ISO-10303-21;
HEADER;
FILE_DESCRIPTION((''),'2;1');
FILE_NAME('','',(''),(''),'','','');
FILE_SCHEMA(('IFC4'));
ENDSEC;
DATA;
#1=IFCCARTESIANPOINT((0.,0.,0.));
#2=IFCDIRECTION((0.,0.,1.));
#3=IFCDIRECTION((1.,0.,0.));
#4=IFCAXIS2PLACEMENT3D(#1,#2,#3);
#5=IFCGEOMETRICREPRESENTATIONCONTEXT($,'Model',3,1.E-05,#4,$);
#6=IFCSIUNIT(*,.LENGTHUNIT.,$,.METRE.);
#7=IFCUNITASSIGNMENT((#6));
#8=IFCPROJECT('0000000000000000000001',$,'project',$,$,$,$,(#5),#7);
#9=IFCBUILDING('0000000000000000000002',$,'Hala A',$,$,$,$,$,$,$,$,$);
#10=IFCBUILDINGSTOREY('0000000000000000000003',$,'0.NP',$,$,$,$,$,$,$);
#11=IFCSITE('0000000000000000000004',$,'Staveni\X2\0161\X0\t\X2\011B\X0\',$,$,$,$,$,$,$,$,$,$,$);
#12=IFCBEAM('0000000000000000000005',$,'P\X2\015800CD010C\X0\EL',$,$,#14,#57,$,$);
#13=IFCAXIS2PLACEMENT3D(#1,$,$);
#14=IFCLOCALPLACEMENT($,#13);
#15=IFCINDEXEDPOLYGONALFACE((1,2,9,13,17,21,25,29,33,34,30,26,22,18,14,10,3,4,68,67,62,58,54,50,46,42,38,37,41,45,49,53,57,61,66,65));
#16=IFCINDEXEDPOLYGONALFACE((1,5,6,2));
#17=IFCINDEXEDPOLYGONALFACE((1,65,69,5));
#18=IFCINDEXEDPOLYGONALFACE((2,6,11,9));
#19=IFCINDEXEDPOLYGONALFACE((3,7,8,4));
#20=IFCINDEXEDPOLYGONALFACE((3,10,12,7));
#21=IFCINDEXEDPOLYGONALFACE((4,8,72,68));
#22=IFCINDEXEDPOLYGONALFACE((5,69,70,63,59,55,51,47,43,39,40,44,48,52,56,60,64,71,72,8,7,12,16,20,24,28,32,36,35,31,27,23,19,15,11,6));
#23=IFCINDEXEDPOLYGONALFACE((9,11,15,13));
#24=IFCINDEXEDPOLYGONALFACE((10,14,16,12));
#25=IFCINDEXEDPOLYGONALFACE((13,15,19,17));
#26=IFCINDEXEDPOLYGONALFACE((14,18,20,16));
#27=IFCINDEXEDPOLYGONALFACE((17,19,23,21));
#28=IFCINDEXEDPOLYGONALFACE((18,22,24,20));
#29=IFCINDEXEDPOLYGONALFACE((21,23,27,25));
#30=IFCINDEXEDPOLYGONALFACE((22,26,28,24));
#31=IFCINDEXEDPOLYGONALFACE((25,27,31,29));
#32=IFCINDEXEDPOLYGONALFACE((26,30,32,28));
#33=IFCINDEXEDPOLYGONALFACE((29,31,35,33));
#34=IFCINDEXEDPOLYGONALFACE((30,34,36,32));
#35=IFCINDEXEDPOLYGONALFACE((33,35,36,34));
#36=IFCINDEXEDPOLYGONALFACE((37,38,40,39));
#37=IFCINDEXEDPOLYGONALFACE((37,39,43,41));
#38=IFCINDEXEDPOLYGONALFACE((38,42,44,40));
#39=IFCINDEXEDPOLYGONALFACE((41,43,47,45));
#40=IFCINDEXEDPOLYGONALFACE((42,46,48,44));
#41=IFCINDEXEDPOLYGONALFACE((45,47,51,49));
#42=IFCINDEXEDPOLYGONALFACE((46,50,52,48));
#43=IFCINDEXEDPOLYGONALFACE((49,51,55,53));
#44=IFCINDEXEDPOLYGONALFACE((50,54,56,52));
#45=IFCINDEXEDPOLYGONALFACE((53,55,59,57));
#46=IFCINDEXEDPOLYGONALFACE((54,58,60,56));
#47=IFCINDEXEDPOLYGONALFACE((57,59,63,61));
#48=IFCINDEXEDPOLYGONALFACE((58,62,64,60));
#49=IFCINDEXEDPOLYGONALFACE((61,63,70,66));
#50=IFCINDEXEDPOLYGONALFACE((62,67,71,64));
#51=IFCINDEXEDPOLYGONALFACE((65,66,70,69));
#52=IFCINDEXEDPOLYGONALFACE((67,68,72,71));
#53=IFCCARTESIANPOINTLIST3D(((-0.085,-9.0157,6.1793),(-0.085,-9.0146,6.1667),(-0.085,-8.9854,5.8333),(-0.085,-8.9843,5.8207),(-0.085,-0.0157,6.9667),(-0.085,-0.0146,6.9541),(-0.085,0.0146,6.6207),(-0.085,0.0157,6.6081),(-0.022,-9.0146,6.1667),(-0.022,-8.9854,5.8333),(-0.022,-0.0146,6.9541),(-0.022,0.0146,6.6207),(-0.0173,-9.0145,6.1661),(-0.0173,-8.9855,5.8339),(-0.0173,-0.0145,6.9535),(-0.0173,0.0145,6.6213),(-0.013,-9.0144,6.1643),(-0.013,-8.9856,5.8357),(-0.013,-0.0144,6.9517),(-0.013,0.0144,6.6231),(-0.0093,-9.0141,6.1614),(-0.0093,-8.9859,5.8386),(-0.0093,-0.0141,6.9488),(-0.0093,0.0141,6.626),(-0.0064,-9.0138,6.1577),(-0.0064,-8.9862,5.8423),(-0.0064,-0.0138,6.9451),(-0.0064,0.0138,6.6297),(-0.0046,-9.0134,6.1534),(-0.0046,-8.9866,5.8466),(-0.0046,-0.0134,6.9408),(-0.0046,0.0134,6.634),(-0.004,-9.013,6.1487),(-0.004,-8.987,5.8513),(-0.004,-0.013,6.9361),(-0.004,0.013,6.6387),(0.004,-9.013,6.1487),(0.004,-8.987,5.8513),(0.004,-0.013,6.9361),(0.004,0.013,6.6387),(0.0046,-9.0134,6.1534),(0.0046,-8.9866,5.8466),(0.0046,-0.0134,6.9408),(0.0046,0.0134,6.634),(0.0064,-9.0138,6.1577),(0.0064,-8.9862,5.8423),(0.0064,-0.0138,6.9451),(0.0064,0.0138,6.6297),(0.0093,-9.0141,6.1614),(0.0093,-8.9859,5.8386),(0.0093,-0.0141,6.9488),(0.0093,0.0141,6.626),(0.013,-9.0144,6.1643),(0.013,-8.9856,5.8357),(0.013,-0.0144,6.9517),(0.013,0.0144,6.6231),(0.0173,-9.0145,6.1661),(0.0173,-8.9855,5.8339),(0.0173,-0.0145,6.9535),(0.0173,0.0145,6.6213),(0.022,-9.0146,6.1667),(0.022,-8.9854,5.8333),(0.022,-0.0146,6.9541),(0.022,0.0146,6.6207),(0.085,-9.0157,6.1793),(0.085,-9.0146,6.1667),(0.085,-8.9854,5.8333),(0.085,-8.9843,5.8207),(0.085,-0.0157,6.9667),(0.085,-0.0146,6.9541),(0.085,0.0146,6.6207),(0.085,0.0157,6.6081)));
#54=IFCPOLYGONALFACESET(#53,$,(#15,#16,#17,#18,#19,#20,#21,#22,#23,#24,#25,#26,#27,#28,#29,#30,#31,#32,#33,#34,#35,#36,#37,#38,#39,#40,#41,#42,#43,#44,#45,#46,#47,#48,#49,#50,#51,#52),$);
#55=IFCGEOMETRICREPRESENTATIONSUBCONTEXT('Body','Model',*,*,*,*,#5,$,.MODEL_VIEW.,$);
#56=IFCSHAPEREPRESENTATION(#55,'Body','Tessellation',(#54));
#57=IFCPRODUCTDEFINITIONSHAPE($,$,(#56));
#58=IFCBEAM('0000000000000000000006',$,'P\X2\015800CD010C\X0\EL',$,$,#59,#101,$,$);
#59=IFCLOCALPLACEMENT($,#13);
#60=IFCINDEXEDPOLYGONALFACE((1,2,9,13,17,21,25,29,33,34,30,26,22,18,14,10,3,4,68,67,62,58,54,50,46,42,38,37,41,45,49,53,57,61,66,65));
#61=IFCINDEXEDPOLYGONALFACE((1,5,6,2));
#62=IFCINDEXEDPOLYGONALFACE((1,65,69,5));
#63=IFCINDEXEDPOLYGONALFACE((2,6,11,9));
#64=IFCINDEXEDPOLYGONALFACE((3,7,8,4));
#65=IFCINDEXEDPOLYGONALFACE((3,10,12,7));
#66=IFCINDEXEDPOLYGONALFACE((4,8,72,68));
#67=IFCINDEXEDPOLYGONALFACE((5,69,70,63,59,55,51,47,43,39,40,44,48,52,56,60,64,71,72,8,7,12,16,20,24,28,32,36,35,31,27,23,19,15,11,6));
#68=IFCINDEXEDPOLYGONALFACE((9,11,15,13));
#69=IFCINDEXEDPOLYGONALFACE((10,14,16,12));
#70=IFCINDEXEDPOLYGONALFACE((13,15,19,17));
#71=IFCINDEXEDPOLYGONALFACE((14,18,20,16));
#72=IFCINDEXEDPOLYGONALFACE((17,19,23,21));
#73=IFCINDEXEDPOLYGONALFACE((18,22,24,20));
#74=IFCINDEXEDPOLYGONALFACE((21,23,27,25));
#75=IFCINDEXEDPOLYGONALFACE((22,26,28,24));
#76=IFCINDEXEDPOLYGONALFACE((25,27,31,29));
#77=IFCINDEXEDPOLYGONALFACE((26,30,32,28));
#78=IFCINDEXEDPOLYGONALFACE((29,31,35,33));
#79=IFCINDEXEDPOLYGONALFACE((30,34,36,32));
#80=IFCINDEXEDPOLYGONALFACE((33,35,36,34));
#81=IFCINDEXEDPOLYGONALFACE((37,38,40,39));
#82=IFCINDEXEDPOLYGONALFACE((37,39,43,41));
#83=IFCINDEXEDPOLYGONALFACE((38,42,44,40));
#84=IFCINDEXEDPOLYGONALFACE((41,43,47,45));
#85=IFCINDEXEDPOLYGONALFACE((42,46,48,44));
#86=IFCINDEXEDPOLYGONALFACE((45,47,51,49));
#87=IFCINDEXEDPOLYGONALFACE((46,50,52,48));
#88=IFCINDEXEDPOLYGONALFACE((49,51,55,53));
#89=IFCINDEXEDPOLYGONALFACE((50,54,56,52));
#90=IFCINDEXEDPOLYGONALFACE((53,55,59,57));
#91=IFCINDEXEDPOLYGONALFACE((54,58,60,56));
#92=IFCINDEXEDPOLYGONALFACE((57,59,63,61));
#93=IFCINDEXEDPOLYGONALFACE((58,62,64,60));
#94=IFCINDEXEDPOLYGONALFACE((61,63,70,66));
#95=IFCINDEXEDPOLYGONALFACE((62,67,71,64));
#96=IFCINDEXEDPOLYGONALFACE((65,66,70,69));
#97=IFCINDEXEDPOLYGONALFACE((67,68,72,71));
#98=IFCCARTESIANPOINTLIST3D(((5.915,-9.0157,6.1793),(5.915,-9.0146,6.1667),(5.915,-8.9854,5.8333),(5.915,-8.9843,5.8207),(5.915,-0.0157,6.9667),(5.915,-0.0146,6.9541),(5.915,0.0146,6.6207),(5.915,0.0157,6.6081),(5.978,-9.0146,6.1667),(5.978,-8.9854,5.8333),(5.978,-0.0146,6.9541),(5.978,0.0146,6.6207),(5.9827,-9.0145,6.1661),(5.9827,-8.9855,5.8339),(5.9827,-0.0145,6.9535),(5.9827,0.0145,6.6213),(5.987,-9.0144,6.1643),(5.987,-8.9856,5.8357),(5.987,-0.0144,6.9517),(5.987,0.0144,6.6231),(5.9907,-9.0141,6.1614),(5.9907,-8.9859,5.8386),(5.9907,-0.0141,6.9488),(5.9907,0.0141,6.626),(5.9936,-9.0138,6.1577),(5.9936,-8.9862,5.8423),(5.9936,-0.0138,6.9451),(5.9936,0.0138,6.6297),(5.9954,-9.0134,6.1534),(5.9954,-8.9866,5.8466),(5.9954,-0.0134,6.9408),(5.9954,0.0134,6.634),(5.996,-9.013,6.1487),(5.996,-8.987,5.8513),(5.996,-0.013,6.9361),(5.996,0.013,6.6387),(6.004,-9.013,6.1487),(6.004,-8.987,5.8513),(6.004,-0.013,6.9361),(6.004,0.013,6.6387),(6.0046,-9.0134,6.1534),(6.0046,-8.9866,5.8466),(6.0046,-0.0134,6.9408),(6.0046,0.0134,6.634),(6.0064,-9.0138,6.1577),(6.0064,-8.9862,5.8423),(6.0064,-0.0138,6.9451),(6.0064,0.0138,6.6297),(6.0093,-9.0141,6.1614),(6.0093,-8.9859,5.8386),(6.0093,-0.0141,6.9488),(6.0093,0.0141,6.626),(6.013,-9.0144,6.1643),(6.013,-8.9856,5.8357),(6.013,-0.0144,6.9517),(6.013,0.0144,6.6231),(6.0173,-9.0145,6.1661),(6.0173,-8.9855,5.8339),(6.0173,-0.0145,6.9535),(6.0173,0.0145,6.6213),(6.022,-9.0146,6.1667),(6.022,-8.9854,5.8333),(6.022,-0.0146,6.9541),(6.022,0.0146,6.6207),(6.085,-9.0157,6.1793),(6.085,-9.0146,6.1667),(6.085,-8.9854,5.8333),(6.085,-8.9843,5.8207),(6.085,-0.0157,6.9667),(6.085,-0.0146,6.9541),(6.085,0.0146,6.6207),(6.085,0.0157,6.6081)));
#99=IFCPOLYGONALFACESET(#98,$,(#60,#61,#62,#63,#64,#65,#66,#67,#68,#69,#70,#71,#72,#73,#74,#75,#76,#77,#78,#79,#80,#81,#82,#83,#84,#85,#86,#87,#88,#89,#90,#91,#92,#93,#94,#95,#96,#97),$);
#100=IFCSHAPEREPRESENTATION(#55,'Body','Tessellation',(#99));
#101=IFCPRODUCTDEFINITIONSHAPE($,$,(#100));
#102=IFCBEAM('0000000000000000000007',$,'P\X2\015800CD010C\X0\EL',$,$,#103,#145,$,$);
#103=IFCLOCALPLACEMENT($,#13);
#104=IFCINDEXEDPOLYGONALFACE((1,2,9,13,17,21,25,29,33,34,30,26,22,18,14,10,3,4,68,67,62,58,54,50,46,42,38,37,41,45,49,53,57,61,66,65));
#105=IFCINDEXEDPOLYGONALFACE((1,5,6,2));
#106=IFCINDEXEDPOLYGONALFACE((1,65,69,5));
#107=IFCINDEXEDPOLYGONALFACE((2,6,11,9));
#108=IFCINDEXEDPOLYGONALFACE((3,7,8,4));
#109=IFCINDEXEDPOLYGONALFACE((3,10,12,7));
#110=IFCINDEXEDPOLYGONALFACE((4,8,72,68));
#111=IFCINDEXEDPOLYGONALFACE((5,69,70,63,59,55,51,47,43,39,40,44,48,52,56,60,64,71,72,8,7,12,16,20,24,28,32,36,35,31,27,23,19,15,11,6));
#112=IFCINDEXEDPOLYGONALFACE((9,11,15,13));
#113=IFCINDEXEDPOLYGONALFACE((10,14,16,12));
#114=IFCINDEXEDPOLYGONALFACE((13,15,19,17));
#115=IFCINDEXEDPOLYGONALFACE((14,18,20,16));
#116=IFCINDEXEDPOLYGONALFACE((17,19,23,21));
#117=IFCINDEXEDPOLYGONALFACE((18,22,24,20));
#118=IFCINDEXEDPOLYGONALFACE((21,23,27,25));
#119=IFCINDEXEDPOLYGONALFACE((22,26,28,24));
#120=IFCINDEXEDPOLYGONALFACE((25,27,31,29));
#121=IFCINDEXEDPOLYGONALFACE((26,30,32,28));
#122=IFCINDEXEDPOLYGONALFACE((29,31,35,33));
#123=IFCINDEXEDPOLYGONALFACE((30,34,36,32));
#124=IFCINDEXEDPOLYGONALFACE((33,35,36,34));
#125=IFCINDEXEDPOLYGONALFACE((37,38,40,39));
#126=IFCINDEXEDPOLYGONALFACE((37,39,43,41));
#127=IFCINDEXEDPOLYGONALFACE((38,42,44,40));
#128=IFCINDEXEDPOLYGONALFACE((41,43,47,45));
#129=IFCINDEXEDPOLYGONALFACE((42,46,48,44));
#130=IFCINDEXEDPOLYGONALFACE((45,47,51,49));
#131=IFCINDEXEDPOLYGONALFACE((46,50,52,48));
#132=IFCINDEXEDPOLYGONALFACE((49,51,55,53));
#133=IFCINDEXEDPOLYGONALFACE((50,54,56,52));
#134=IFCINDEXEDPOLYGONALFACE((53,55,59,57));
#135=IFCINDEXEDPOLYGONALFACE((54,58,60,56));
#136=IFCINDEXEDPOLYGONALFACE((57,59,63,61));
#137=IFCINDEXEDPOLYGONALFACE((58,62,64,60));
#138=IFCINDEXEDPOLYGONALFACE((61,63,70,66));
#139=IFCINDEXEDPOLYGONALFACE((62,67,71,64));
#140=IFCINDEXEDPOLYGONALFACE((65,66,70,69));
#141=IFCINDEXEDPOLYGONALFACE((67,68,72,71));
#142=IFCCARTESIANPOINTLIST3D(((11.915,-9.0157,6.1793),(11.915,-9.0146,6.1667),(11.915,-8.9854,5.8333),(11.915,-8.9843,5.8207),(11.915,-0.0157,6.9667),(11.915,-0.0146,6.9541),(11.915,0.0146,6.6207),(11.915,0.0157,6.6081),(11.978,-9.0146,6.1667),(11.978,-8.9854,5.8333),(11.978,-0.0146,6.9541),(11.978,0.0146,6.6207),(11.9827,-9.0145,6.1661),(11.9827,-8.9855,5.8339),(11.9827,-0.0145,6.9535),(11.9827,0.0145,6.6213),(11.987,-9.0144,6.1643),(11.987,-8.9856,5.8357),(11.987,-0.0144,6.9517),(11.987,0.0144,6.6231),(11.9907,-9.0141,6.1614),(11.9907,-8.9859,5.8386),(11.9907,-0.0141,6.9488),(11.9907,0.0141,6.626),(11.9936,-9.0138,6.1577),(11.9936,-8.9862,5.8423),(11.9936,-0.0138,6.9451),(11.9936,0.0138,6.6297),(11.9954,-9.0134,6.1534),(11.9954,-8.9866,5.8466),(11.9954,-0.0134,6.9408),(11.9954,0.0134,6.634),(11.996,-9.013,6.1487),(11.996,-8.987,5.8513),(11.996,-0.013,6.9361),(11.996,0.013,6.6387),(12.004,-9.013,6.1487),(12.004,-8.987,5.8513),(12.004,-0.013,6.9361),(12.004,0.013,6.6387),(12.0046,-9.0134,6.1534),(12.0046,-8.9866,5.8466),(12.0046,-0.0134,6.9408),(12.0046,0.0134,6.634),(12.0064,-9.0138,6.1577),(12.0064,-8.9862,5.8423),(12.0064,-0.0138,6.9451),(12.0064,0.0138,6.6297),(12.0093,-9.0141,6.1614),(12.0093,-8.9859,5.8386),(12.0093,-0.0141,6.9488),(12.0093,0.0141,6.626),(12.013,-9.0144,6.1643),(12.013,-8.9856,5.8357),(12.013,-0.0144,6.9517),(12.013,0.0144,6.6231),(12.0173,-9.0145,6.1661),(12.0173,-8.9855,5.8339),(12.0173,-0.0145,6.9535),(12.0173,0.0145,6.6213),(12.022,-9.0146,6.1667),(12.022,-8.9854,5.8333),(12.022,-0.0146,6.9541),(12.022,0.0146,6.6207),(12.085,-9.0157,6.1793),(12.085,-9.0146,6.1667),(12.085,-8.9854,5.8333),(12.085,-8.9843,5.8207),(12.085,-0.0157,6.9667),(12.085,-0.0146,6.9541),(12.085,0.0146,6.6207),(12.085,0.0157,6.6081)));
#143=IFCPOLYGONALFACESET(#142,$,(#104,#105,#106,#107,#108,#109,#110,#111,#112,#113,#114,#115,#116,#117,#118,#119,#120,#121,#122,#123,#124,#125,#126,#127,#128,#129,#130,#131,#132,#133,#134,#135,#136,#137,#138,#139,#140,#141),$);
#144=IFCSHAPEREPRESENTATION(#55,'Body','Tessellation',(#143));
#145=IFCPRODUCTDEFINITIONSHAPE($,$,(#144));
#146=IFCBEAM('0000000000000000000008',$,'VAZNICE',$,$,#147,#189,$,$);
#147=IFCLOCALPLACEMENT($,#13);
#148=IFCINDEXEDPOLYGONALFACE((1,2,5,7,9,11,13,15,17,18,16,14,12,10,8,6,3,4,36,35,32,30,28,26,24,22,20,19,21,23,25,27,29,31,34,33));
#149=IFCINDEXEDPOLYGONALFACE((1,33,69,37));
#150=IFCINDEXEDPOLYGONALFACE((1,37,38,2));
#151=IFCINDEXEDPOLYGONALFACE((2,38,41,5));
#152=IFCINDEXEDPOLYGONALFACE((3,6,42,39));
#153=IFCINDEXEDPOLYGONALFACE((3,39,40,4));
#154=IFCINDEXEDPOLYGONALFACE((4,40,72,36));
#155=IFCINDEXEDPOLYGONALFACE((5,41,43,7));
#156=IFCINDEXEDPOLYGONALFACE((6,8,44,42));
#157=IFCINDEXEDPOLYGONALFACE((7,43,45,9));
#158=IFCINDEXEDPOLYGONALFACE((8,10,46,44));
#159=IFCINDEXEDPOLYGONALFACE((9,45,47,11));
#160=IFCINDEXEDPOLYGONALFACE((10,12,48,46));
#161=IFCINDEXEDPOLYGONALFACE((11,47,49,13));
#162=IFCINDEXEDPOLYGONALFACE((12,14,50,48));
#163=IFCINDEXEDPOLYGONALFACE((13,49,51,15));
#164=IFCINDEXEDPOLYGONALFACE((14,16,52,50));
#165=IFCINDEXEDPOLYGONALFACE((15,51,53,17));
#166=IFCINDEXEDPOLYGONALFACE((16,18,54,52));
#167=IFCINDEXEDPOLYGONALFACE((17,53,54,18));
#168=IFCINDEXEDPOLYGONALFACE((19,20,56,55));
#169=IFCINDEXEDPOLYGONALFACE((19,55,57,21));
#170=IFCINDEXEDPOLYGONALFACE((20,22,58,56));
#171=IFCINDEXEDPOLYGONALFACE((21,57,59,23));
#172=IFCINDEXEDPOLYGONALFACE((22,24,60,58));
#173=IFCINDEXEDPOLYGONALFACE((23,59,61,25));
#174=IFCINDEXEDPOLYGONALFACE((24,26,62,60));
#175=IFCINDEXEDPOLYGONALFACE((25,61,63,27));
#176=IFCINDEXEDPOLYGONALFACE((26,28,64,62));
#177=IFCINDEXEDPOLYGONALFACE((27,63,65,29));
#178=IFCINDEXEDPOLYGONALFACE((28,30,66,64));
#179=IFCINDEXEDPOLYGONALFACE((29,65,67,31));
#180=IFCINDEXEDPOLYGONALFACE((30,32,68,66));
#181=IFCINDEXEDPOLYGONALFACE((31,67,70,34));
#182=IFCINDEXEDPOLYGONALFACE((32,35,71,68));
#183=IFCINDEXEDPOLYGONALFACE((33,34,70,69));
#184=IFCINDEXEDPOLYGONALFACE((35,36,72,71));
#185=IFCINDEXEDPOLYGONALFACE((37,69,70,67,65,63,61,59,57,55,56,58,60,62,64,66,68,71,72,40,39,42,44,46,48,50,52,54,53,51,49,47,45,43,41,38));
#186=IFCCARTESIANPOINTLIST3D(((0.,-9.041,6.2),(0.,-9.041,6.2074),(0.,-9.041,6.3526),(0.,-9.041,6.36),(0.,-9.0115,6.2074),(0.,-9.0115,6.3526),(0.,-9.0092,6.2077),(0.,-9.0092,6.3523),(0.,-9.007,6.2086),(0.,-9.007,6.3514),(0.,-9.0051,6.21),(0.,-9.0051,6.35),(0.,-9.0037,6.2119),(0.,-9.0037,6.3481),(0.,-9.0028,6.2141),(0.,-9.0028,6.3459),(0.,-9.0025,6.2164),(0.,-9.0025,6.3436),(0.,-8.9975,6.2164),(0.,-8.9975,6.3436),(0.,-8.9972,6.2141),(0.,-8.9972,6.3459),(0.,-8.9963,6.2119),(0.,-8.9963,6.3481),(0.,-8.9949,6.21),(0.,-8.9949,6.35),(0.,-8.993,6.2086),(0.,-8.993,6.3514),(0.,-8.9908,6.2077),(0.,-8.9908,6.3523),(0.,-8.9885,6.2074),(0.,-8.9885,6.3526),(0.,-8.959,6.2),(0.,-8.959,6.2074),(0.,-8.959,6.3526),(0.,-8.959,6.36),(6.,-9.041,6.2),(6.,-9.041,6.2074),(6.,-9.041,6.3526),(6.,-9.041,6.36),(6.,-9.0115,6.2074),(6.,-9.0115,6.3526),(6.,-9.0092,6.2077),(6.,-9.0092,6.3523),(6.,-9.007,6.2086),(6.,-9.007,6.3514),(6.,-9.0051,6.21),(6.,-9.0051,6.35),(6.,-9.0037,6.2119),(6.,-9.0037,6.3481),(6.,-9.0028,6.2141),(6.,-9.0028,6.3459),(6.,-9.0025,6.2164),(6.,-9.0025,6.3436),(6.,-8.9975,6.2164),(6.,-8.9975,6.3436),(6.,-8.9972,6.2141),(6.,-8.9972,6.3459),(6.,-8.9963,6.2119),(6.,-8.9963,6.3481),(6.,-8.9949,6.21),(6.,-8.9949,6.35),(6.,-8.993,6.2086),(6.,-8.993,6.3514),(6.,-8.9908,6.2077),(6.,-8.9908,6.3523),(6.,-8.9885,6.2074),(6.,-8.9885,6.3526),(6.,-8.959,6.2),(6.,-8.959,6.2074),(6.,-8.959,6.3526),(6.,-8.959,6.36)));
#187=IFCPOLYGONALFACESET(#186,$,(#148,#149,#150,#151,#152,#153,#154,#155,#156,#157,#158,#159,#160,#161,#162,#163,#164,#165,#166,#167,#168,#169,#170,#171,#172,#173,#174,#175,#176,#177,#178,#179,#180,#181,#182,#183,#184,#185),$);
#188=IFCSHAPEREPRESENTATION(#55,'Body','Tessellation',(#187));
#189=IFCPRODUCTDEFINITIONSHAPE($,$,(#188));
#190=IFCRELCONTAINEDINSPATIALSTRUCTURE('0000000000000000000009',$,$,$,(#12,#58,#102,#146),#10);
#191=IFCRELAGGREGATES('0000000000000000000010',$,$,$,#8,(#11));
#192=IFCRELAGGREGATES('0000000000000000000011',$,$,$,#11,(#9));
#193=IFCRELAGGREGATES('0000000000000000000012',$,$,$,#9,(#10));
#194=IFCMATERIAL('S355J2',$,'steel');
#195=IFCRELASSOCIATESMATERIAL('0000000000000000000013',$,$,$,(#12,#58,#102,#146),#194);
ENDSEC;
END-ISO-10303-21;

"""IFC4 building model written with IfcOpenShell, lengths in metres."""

from ifc_helpers import new_model, si_unit, frame, origin_with_axes, place, context, subcontext, project, spatial, i_section, extrude, material, element, save


model = new_model("IFC4")

# Units and contexts
model_context = context("Model", 3, precision=1e-05, world=origin_with_axes())
body_context = subcontext(model_context, "Body", "Model", "MODEL_VIEW")
ifc_project = project(units=[si_unit("LENGTHUNIT", "METRE")], contexts=[model_context])

# Site, building, storey
site = spatial("IfcSite", under=ifc_project, Name="Staveniště")
building = spatial("IfcBuilding", under=site, Name="Hala A")
storey = spatial("IfcBuildingStorey", under=building, Name="0.NP")

# Shared definitions
ifc_material = material(Name="S355J2", Category="steel")

# Beams
for number, where, z_axis, x_axis, name in (
    (1, (0.0, -9.0, 6.0), (0.0, 0.996195, 0.087156), (-1.0, 0.0, 0.0), "PŘÍČEL"),
    (2, (6.0, -9.0, 6.0), (0.0, 0.996195, 0.087156), (-1.0, 0.0, 0.0), "PŘÍČEL"),
    (3, (12.0, -9.0, 6.0), (0.0, 0.996195, 0.087156), (-1.0, 0.0, 0.0), "PŘÍČEL"),
):
    element("IfcBeam", number, at=place(None, frame(where, z_axis=z_axis, x_axis=x_axis)), inside=storey, material=ifc_material, Name=name, context=body_context, shape_type="SweptSolid", body=[
        extrude(i_section(OverallWidth=0.17, OverallDepth=0.36, WebThickness=0.008, FlangeThickness=0.0127, FilletRadius=0.018), origin_with_axes(), (0.0, 0.0, 1.0), 9.0344),
    ])
for number, where, z_axis, x_axis, name in (
    (4, (0.0, -9.0, 6.28), (1.0, 0.0, 0.0), (0.0, 1.0, 0.0), "VAZNICE"),
):
    element("IfcBeam", number, at=place(None, frame(where, z_axis=z_axis, x_axis=x_axis)), inside=storey, material=ifc_material, Name=name, context=body_context, shape_type="SweptSolid", body=[
        extrude(i_section(OverallWidth=0.082, OverallDepth=0.16, WebThickness=0.005, FlangeThickness=0.0074, FilletRadius=0.009), origin_with_axes(), (0.0, 0.0, 1.0), 6.0),
    ])

save(model, "model.ifc")
